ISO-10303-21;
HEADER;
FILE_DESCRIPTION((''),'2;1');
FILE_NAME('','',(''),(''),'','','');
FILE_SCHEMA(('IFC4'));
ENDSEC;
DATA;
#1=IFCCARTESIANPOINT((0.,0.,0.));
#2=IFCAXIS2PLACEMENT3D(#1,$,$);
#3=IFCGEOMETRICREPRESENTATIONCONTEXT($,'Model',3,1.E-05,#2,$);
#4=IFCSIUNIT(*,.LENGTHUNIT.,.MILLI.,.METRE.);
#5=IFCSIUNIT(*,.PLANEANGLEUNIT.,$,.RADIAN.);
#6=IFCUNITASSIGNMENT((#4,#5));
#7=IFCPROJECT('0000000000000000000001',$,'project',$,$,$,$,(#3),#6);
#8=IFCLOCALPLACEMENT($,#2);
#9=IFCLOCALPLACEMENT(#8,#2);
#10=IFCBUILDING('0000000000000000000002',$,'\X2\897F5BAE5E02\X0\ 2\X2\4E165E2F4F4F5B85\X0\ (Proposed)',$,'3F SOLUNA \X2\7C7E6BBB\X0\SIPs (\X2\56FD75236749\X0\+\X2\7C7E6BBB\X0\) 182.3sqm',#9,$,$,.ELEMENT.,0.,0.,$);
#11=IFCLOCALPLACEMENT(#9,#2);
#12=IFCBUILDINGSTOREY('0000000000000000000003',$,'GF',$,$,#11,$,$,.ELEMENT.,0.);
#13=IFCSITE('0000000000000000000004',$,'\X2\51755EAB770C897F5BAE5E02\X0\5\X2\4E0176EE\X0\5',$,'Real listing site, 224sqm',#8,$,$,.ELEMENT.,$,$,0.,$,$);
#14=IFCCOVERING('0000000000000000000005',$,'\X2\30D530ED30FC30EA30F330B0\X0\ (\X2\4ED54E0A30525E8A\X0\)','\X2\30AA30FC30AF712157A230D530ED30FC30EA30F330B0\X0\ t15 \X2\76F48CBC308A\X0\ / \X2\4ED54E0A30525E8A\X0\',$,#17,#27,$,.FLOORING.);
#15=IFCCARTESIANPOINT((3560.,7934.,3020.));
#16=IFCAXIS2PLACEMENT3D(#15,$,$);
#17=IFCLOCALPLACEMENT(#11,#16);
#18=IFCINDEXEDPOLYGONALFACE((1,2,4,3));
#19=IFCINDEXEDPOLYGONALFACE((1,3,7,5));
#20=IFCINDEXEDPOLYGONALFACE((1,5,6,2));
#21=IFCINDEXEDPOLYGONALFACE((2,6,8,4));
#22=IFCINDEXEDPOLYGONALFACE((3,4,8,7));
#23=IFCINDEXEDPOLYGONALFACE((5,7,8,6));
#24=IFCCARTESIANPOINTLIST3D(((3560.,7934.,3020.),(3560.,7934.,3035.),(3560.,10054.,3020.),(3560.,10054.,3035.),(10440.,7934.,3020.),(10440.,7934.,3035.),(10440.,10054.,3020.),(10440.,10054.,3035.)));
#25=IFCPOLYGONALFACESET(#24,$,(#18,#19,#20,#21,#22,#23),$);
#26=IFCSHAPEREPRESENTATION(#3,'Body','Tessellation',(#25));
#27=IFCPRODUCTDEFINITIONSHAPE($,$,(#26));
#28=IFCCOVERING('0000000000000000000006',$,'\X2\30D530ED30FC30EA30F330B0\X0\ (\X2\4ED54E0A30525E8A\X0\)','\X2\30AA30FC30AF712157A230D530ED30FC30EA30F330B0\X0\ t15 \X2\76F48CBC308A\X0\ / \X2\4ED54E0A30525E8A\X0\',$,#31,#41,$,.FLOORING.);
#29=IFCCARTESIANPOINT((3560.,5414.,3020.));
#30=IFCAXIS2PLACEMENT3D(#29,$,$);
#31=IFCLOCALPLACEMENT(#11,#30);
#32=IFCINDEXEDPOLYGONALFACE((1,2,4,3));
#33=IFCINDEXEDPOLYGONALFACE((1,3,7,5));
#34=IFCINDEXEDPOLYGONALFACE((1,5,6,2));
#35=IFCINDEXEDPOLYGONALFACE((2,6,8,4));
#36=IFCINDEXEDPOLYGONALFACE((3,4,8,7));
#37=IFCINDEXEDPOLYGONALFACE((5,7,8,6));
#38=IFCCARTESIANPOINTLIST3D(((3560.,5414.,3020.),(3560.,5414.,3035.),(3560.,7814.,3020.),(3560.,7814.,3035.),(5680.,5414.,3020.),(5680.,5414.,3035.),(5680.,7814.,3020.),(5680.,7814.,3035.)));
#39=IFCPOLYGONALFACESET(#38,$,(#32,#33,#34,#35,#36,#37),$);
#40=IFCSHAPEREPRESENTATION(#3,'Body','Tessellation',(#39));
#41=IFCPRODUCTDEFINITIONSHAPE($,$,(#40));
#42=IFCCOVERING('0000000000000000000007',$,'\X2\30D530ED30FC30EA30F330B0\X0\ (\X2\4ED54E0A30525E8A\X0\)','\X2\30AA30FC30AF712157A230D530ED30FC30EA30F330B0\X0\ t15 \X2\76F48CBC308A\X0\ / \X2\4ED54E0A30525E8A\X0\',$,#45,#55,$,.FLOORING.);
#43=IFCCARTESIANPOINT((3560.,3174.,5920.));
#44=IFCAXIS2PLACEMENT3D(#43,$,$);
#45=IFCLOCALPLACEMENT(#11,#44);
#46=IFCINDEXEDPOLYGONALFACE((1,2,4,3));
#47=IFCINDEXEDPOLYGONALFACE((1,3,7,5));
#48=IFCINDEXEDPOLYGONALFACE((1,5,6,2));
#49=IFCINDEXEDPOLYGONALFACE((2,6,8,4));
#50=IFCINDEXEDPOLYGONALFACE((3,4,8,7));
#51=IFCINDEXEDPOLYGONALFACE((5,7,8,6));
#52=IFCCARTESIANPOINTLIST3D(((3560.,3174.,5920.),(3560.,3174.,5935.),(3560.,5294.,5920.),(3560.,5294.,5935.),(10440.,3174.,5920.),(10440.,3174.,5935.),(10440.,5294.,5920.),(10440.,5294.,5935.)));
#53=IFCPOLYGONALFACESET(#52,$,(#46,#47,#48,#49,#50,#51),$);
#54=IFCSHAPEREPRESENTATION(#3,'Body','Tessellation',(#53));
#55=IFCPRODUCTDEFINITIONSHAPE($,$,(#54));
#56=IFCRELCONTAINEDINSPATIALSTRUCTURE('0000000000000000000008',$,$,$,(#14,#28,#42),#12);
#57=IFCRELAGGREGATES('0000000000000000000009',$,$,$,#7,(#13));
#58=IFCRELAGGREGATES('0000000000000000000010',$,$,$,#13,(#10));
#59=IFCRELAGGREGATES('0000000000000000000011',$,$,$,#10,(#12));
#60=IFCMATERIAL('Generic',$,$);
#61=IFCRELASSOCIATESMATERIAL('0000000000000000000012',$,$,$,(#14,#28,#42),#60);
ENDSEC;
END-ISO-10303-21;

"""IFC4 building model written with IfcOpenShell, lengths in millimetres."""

from ifc_helpers import new_model, si_unit, frame, frame_2d, origin, place, context, project, spatial, rectangle, extrude, material, element, save


model = new_model("IFC4")

# Units and contexts
model_context = context("Model", 3, precision=1e-05, world=origin())
ifc_project = project(units=[si_unit("LENGTHUNIT", "METRE", prefix="MILLI"), si_unit("PLANEANGLEUNIT", "RADIAN")], contexts=[model_context])

# Site, building, storey
site_placement = place(None, origin())
site = spatial("IfcSite", under=ifc_project, at=site_placement, Name="兵庫県西宮市5丁目5", ObjectType="Real listing site, 224sqm", CompositionType="ELEMENT", RefElevation=0.0)
building_placement = place(site_placement, origin())
building = spatial("IfcBuilding", under=site, at=building_placement, Name="西宮市 2世帯住宅 (Proposed)", ObjectType="3F SOLUNA 籾殻SIPs (国産杉+籾殻) 182.3sqm", CompositionType="ELEMENT", ElevationOfRefHeight=0.0, ElevationOfTerrain=0.0)
storey_placement = place(building_placement, origin())
storey = spatial("IfcBuildingStorey", under=building, at=storey_placement, Name="GF", CompositionType="ELEMENT", Elevation=0.0)

# Shared definitions
ifc_material_1 = material(Name="Generic")

# Coverings
covering_1_placement = place(storey_placement, frame((3560.0, 7934.0, 3020.0)))
element("IfcCovering", 1, at=covering_1_placement, inside=storey, material=ifc_material_1, Name="フローリング (仕上げ床)", Description="オーク無垢フローリング t15 直貼り / 仕上げ床", PredefinedType="FLOORING", context=model_context, shape_type="SweptSolid", body=[
    extrude(rectangle(XDim=6880.0, YDim=2120.0, at=frame_2d((3440.0, 1060.0))), frame((3560.0, 7934.0, 3020.0)), (0.0, 0.0, 1.0), 15.0),
])
covering_2_placement = place(storey_placement, frame((3560.0, 5414.0, 3020.0)))
element("IfcCovering", 2, at=covering_2_placement, inside=storey, material=ifc_material_1, Name="フローリング (仕上げ床)", Description="オーク無垢フローリング t15 直貼り / 仕上げ床", PredefinedType="FLOORING", context=model_context, shape_type="SweptSolid", body=[
    extrude(rectangle(XDim=2120.0, YDim=2400.0, at=frame_2d((1060.0, 1200.0))), frame((3560.0, 5414.0, 3020.0)), (0.0, 0.0, 1.0), 15.0),
])
covering_3_placement = place(storey_placement, frame((3560.0, 3174.0, 5920.0)))
element("IfcCovering", 3, at=covering_3_placement, inside=storey, material=ifc_material_1, Name="フローリング (仕上げ床)", Description="オーク無垢フローリング t15 直貼り / 仕上げ床", PredefinedType="FLOORING", context=model_context, shape_type="SweptSolid", body=[
    extrude(rectangle(XDim=6880.0, YDim=2120.0, at=frame_2d((3440.0, 1060.0))), frame((3560.0, 3174.0, 5920.0)), (0.0, 0.0, 1.0), 15.0),
])

save(model, "model.ifc")
